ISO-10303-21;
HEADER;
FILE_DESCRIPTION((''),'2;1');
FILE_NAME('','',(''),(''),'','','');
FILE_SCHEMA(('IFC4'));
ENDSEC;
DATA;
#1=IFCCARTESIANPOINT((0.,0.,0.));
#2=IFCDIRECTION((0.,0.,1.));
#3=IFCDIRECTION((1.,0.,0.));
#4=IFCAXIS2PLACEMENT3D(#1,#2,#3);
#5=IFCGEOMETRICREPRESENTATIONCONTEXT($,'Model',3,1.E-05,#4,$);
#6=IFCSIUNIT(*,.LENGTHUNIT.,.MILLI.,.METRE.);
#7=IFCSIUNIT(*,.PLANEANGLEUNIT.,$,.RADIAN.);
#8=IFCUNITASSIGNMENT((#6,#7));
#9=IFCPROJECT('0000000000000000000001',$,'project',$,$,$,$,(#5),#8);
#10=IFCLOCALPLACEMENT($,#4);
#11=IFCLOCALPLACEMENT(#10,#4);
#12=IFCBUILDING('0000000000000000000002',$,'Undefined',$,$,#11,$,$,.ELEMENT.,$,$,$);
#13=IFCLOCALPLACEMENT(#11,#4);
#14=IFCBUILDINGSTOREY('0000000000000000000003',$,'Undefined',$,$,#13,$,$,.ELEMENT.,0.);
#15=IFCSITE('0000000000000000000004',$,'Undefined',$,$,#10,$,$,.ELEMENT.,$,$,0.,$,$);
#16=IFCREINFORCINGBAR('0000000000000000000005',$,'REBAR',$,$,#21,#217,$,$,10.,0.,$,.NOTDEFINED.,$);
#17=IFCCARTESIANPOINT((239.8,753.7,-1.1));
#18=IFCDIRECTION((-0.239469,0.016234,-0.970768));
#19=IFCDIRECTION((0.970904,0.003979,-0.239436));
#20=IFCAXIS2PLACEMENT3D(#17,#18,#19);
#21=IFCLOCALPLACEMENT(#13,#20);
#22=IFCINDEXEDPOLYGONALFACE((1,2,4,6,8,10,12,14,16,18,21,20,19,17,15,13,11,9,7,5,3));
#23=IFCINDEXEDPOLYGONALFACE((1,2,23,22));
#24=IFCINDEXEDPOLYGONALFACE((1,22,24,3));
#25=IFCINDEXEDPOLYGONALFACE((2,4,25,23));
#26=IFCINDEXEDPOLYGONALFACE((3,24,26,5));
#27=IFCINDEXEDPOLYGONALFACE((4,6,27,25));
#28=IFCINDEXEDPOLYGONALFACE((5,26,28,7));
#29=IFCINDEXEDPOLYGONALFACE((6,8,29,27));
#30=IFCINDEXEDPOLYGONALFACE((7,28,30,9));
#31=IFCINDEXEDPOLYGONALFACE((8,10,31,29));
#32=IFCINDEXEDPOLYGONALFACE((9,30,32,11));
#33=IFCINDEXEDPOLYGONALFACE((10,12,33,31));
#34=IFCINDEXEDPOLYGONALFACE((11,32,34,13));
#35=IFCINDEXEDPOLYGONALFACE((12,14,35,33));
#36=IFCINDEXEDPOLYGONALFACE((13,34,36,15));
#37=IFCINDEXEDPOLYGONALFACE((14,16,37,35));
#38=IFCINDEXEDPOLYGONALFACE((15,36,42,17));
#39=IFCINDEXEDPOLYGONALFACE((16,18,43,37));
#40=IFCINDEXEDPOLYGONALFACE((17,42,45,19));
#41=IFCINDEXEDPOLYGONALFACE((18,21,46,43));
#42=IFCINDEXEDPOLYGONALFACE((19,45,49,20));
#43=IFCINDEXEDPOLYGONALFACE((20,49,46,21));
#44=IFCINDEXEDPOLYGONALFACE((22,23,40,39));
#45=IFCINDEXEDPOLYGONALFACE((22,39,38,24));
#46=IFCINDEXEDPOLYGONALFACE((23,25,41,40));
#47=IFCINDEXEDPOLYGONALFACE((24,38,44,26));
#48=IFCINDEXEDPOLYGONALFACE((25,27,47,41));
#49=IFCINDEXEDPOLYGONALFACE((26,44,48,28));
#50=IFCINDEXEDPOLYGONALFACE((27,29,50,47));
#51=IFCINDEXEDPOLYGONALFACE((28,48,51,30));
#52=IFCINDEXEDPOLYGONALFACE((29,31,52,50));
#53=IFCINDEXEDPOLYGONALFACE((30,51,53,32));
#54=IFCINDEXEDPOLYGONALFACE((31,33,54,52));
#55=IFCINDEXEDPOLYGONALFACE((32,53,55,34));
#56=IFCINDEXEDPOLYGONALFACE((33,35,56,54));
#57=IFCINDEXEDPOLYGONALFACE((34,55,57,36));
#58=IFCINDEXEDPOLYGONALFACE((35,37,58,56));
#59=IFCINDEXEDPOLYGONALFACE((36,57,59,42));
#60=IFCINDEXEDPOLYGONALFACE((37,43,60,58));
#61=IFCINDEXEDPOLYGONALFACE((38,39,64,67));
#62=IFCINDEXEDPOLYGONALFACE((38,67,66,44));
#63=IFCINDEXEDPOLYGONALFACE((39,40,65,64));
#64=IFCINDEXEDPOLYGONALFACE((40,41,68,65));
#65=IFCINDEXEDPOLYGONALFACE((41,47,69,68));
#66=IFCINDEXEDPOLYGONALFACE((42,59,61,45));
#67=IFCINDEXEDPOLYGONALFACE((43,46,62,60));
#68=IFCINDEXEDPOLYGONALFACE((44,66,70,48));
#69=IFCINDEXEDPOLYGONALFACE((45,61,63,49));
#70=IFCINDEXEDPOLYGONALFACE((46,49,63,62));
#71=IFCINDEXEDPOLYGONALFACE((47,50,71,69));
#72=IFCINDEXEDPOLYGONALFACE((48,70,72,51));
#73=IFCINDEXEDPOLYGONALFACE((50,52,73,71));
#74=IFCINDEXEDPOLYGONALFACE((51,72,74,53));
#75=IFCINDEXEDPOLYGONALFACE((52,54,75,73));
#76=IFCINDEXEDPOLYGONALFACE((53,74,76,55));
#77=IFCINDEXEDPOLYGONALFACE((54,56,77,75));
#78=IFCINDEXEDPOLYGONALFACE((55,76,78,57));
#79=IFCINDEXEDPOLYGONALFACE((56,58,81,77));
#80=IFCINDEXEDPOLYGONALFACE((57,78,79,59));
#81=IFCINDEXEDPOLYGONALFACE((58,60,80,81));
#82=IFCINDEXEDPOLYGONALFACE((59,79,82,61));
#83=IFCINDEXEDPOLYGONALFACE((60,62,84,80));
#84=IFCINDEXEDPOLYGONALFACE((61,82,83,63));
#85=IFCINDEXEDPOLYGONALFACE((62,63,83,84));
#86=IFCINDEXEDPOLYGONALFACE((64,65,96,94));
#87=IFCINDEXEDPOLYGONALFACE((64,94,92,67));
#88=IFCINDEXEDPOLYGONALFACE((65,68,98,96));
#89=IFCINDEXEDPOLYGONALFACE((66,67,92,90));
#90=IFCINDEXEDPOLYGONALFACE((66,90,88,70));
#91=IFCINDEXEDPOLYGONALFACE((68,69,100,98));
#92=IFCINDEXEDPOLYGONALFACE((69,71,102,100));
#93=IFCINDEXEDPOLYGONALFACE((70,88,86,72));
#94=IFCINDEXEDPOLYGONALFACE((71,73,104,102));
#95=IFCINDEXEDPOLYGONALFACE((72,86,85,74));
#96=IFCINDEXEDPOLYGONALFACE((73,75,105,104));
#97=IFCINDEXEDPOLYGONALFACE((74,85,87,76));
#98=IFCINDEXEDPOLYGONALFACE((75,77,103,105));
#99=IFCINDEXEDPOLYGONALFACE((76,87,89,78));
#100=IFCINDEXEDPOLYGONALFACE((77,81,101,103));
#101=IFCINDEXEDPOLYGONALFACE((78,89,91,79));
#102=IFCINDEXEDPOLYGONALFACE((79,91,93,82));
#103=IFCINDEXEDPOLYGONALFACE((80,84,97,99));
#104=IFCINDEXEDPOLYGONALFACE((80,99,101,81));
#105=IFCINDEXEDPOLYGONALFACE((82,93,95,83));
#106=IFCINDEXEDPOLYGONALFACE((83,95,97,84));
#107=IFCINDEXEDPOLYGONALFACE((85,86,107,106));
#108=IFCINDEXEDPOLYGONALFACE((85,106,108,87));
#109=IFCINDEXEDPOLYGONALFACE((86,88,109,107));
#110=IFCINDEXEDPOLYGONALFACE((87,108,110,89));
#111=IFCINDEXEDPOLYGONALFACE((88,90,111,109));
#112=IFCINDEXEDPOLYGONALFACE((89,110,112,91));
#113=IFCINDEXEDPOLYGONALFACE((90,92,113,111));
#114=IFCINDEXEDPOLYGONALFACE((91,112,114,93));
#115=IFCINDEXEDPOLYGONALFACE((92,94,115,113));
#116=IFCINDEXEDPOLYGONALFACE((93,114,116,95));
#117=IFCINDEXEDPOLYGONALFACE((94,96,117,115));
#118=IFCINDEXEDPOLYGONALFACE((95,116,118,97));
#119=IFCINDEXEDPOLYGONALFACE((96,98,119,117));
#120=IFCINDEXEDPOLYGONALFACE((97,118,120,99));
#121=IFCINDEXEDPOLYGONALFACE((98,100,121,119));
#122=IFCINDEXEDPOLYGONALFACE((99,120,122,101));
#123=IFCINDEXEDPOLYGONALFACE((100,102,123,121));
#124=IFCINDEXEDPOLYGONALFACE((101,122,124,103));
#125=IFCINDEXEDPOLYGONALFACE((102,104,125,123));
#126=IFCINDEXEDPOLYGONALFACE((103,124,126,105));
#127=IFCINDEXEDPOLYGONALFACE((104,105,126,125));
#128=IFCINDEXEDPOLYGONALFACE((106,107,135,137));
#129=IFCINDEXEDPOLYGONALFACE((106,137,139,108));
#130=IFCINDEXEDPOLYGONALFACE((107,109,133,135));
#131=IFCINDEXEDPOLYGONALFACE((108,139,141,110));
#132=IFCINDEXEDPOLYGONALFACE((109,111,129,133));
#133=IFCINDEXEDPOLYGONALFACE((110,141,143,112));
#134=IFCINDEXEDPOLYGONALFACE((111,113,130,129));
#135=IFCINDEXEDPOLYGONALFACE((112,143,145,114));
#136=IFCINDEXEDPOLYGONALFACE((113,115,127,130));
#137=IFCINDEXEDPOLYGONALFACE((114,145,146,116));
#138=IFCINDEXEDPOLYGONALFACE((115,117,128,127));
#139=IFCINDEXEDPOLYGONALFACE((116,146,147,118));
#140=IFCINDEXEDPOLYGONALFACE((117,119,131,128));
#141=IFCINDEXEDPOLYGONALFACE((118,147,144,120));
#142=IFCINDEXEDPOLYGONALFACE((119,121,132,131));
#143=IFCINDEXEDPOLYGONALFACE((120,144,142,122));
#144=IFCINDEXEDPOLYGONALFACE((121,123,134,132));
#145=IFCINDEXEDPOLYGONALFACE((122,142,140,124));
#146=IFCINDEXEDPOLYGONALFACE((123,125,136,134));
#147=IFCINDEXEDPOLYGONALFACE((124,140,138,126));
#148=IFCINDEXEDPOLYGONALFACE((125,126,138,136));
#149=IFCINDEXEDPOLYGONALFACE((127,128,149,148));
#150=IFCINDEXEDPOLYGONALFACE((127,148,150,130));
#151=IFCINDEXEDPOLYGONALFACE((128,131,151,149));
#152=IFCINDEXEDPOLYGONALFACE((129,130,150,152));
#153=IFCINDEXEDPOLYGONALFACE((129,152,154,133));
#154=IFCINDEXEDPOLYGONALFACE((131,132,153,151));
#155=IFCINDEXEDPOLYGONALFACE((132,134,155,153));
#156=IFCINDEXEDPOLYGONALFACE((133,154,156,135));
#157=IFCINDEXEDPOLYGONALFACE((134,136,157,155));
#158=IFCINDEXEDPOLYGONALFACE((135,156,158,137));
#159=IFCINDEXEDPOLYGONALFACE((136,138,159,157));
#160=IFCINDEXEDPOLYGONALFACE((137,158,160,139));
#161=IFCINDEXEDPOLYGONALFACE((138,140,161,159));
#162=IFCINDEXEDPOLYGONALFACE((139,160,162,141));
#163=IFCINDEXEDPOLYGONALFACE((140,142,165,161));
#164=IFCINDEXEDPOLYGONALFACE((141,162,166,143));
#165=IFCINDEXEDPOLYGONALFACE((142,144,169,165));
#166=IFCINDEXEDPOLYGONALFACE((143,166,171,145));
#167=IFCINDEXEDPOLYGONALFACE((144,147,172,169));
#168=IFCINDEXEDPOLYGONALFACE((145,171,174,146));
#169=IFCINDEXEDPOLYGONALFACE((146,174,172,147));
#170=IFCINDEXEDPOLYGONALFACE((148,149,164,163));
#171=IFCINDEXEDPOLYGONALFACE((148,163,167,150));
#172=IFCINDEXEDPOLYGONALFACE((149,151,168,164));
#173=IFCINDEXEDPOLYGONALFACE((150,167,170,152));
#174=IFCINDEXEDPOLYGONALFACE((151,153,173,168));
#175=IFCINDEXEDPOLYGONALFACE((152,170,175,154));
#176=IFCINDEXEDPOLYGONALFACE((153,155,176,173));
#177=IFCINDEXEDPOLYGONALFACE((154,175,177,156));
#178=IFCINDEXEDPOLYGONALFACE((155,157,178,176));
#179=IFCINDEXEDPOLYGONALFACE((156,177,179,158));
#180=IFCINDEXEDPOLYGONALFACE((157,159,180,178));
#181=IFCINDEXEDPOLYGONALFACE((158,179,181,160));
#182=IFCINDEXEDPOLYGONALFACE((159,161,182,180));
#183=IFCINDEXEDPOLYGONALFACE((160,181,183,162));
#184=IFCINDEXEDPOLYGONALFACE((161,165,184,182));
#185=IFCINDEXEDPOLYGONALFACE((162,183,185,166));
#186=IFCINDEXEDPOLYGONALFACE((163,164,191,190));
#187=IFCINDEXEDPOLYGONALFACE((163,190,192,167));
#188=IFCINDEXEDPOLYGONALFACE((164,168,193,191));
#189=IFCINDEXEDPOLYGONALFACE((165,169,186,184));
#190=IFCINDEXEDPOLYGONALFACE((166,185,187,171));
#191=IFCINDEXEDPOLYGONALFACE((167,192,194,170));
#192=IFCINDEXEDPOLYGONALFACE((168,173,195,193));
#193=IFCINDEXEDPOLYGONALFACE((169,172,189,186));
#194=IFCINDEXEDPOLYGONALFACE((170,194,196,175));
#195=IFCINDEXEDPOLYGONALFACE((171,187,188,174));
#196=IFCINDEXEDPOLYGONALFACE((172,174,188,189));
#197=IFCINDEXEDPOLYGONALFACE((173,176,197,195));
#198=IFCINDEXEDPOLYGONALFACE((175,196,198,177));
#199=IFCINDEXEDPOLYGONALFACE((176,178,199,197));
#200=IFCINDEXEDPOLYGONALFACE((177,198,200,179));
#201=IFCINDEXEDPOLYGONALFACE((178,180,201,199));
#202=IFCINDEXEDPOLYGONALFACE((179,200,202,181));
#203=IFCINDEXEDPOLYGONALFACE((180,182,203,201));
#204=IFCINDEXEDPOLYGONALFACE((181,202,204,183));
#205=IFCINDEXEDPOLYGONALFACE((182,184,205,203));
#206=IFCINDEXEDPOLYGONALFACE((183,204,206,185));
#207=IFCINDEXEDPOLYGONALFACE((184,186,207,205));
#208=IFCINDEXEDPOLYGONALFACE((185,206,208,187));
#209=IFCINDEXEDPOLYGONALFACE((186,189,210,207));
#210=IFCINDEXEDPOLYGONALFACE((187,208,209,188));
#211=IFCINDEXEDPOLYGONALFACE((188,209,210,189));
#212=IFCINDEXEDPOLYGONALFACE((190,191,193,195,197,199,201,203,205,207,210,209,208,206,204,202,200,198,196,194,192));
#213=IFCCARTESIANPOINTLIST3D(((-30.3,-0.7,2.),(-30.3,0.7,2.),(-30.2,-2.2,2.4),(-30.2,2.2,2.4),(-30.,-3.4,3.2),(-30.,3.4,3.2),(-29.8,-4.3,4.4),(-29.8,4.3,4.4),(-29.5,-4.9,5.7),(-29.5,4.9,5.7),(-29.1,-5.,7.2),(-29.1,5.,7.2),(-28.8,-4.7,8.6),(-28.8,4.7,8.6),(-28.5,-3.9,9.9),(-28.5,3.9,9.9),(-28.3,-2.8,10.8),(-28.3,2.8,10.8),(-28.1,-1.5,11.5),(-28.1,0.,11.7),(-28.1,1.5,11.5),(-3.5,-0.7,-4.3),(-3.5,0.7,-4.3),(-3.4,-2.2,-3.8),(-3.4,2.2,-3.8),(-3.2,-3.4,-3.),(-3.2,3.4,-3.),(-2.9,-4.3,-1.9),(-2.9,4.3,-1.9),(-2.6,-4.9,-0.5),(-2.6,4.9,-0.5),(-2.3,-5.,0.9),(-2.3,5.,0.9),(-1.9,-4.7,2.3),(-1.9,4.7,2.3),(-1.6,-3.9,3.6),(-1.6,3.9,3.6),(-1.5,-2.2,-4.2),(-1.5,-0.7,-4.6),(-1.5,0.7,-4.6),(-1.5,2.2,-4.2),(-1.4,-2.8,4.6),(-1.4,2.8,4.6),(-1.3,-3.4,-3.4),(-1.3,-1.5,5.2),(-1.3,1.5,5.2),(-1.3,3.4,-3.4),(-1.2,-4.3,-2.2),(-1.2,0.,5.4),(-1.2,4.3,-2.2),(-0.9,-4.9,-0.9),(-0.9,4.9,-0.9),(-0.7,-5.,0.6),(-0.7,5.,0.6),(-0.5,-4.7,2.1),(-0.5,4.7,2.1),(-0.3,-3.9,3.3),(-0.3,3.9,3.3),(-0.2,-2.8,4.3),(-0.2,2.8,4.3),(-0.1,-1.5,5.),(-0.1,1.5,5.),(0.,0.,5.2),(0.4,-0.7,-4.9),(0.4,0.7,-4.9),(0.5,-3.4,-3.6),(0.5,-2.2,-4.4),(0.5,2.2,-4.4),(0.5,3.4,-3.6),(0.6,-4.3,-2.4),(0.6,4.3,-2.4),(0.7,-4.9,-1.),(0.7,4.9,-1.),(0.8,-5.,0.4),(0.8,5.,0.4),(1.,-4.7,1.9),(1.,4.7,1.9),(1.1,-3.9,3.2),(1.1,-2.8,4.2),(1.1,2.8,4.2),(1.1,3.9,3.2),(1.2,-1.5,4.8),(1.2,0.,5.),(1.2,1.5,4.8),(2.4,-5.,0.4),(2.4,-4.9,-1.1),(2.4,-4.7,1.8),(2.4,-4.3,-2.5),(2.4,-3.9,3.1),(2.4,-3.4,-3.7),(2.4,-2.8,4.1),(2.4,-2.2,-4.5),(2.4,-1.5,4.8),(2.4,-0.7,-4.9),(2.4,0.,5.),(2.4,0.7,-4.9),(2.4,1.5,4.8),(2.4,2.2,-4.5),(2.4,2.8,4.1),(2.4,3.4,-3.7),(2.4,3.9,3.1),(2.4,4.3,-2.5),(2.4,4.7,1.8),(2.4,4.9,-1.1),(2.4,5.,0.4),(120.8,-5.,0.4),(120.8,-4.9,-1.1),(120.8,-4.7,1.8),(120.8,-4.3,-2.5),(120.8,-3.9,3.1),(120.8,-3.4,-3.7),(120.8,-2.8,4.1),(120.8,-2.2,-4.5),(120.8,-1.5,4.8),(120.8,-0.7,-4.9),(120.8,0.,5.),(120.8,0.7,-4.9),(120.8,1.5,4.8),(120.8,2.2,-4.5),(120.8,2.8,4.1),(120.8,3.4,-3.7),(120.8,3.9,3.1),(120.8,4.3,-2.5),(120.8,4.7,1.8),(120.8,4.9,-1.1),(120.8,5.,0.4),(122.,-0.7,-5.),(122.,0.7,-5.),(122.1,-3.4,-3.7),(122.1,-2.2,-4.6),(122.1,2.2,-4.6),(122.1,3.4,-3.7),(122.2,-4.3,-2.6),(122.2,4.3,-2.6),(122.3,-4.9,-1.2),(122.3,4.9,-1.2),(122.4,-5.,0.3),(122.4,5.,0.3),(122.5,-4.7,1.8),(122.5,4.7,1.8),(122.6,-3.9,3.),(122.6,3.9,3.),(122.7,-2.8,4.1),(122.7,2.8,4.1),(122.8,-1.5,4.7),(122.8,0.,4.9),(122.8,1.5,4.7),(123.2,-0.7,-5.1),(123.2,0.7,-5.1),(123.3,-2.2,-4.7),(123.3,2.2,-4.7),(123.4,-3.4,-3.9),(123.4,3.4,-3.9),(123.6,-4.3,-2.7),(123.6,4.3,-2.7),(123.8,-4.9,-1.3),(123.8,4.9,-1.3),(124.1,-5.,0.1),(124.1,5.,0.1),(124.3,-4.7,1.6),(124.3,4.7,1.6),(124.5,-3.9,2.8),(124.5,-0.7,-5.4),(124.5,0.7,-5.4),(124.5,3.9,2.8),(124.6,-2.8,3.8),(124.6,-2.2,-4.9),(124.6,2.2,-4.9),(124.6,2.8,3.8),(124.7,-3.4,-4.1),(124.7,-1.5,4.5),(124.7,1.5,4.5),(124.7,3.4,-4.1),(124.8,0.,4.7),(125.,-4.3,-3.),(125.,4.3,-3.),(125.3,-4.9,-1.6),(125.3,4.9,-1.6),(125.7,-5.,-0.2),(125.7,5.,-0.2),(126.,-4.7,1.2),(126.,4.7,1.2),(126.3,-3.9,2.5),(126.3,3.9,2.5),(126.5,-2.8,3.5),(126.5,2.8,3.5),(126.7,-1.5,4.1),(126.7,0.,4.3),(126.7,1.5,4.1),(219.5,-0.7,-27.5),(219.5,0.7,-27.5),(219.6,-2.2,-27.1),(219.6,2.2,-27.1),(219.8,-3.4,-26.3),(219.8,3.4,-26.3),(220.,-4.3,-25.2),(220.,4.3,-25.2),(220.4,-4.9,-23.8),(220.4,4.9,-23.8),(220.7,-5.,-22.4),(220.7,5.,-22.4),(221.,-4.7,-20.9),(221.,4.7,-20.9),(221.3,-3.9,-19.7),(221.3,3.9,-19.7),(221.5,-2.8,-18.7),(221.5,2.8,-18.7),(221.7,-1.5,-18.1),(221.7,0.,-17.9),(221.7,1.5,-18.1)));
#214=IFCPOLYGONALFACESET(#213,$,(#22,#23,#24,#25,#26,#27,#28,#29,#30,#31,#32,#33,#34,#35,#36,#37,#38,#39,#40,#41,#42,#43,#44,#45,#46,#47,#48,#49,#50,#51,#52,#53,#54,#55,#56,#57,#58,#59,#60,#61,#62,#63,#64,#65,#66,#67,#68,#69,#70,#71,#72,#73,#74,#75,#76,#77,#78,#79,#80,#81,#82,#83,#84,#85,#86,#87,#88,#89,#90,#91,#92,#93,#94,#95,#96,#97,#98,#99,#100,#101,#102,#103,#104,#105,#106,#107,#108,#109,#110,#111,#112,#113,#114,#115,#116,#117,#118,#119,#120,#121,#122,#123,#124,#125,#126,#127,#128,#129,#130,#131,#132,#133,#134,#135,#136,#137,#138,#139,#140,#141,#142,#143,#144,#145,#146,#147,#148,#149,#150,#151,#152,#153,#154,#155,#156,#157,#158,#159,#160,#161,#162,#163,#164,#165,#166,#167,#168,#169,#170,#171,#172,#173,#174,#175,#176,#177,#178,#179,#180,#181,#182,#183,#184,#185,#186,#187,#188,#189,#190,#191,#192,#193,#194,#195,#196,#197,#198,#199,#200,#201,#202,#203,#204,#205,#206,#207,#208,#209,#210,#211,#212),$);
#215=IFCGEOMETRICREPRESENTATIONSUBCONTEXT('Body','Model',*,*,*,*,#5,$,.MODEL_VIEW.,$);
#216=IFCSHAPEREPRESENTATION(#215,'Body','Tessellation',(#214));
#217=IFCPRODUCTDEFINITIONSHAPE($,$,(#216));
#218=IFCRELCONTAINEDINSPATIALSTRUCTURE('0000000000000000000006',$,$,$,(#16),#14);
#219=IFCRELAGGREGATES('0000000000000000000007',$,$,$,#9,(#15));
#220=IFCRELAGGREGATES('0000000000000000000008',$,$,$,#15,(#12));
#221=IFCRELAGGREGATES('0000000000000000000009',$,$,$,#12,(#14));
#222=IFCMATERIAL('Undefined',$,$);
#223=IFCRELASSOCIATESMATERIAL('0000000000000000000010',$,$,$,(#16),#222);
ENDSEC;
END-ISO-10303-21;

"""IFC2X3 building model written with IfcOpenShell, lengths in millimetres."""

from ifc_helpers import new_model, entity, si_unit, frame, origin_with_axes, place, context, subcontext, project, spatial, source, transform, mapped, material, element, save


model = new_model("IFC2X3")

# Units and contexts
model_context = context("Model", 3, precision=1e-05, world=origin_with_axes())
body_context = subcontext(model_context, "Body", "Model", "MODEL_VIEW")
ifc_project = project(units=[si_unit("LENGTHUNIT", "METRE", prefix="MILLI"), si_unit("PLANEANGLEUNIT", "RADIAN")], contexts=[model_context])

# Site, building, storey
site_placement = place(None, origin_with_axes())
site = spatial("IfcSite", under=ifc_project, at=site_placement, Name="Undefined", CompositionType="ELEMENT", RefElevation=0.0)
building_placement = place(site_placement, origin_with_axes())
building = spatial("IfcBuilding", under=site, at=building_placement, Name="Undefined", CompositionType="ELEMENT")
storey_placement = place(building_placement, origin_with_axes())
storey = spatial("IfcBuildingStorey", under=building, at=storey_placement, Name="Undefined", CompositionType="ELEMENT", Elevation=0.0)

# Reinforcing bar
ifc_material_1 = material(Name="Undefined")
vector_1 = entity("IfcVector", entity("IfcDirection", [0.973841, 0.0, -0.22723]), 1.0)
shared_shape_1 = source(origin_with_axes(), body_context, "Body", "AdvancedSweptSolid", [
    entity("IfcSweptDiskSolid", entity("IfcCompositeCurve", [entity("IfcCompositeCurveSegment", "CONTINUOUS", True, entity("IfcTrimmedCurve", entity("IfcLine", entity("IfcCartesianPoint", [0.0, 0.0, 0.0]), vector_1), [entity("IfcParameterValue", 0.0)], [entity("IfcParameterValue", 27.582469)], True, "PARAMETER")), entity("IfcCompositeCurveSegment", "CONTINUOUS", True, entity("IfcTrimmedCurve", entity("IfcCircle", entity("IfcAxis2Placement3D", entity("IfcCartesianPoint", [31.6, 0.0, 14.2]), entity("IfcDirection", [0.0, -1.0, 0.0]), entity("IfcDirection", [-0.22723, 0.0, -0.973841])), 21.0), [entity("IfcParameterValue", 0.0)], [entity("IfcParameterValue", 0.229232)], True, "PARAMETER")), entity("IfcCompositeCurveSegment", "CONTINUOUS", True, entity("IfcTrimmedCurve", entity("IfcLine", entity("IfcCartesianPoint", [31.6, 0.0, -6.8]), entity("IfcVector", entity("IfcDirection", [1.0, 0.0, 0.0]), 1.0)), [entity("IfcParameterValue", 0.0)], [entity("IfcParameterValue", 118.388313)], True, "PARAMETER")), entity("IfcCompositeCurveSegment", "CONTINUOUS", True, entity("IfcTrimmedCurve", entity("IfcCircle", entity("IfcAxis2Placement3D", entity("IfcCartesianPoint", [150.0, 0.0, -27.8]), entity("IfcDirection", [0.0, 1.0, 0.0]), entity("IfcDirection", [0.0, 0.0, 1.0])), 21.0), [entity("IfcParameterValue", 0.0)], [entity("IfcParameterValue", 0.229232)], True, "PARAMETER")), entity("IfcCompositeCurveSegment", "DISCONTINUOUS", True, entity("IfcTrimmedCurve", entity("IfcLine", entity("IfcCartesianPoint", [154.8, 0.0, -7.4]), vector_1), [entity("IfcParameterValue", 0.0)], [entity("IfcParameterValue", 97.582469)], True, "PARAMETER"))], False), 5.0, None, 0.0, 244.0),
])
reinforcing_bar_1_placement = place(storey_placement, frame((239.8, 753.7, -1.1), z_axis=(-0.239469, 0.016234, -0.970768), x_axis=(0.970904, 0.003979, -0.239436)))
element("IfcReinforcingBar", 1, at=reinforcing_bar_1_placement, inside=storey, material=ifc_material_1, Name="REBAR", BarRole="NOTDEFINED", CrossSectionArea=0.0, NominalDiameter=10.0, context=body_context, shape_type="MappedRepresentation", body=[
    mapped(shared_shape_1, transform((-29.2, 0.0, 6.8))),
])

save(model, "model.ifc")
